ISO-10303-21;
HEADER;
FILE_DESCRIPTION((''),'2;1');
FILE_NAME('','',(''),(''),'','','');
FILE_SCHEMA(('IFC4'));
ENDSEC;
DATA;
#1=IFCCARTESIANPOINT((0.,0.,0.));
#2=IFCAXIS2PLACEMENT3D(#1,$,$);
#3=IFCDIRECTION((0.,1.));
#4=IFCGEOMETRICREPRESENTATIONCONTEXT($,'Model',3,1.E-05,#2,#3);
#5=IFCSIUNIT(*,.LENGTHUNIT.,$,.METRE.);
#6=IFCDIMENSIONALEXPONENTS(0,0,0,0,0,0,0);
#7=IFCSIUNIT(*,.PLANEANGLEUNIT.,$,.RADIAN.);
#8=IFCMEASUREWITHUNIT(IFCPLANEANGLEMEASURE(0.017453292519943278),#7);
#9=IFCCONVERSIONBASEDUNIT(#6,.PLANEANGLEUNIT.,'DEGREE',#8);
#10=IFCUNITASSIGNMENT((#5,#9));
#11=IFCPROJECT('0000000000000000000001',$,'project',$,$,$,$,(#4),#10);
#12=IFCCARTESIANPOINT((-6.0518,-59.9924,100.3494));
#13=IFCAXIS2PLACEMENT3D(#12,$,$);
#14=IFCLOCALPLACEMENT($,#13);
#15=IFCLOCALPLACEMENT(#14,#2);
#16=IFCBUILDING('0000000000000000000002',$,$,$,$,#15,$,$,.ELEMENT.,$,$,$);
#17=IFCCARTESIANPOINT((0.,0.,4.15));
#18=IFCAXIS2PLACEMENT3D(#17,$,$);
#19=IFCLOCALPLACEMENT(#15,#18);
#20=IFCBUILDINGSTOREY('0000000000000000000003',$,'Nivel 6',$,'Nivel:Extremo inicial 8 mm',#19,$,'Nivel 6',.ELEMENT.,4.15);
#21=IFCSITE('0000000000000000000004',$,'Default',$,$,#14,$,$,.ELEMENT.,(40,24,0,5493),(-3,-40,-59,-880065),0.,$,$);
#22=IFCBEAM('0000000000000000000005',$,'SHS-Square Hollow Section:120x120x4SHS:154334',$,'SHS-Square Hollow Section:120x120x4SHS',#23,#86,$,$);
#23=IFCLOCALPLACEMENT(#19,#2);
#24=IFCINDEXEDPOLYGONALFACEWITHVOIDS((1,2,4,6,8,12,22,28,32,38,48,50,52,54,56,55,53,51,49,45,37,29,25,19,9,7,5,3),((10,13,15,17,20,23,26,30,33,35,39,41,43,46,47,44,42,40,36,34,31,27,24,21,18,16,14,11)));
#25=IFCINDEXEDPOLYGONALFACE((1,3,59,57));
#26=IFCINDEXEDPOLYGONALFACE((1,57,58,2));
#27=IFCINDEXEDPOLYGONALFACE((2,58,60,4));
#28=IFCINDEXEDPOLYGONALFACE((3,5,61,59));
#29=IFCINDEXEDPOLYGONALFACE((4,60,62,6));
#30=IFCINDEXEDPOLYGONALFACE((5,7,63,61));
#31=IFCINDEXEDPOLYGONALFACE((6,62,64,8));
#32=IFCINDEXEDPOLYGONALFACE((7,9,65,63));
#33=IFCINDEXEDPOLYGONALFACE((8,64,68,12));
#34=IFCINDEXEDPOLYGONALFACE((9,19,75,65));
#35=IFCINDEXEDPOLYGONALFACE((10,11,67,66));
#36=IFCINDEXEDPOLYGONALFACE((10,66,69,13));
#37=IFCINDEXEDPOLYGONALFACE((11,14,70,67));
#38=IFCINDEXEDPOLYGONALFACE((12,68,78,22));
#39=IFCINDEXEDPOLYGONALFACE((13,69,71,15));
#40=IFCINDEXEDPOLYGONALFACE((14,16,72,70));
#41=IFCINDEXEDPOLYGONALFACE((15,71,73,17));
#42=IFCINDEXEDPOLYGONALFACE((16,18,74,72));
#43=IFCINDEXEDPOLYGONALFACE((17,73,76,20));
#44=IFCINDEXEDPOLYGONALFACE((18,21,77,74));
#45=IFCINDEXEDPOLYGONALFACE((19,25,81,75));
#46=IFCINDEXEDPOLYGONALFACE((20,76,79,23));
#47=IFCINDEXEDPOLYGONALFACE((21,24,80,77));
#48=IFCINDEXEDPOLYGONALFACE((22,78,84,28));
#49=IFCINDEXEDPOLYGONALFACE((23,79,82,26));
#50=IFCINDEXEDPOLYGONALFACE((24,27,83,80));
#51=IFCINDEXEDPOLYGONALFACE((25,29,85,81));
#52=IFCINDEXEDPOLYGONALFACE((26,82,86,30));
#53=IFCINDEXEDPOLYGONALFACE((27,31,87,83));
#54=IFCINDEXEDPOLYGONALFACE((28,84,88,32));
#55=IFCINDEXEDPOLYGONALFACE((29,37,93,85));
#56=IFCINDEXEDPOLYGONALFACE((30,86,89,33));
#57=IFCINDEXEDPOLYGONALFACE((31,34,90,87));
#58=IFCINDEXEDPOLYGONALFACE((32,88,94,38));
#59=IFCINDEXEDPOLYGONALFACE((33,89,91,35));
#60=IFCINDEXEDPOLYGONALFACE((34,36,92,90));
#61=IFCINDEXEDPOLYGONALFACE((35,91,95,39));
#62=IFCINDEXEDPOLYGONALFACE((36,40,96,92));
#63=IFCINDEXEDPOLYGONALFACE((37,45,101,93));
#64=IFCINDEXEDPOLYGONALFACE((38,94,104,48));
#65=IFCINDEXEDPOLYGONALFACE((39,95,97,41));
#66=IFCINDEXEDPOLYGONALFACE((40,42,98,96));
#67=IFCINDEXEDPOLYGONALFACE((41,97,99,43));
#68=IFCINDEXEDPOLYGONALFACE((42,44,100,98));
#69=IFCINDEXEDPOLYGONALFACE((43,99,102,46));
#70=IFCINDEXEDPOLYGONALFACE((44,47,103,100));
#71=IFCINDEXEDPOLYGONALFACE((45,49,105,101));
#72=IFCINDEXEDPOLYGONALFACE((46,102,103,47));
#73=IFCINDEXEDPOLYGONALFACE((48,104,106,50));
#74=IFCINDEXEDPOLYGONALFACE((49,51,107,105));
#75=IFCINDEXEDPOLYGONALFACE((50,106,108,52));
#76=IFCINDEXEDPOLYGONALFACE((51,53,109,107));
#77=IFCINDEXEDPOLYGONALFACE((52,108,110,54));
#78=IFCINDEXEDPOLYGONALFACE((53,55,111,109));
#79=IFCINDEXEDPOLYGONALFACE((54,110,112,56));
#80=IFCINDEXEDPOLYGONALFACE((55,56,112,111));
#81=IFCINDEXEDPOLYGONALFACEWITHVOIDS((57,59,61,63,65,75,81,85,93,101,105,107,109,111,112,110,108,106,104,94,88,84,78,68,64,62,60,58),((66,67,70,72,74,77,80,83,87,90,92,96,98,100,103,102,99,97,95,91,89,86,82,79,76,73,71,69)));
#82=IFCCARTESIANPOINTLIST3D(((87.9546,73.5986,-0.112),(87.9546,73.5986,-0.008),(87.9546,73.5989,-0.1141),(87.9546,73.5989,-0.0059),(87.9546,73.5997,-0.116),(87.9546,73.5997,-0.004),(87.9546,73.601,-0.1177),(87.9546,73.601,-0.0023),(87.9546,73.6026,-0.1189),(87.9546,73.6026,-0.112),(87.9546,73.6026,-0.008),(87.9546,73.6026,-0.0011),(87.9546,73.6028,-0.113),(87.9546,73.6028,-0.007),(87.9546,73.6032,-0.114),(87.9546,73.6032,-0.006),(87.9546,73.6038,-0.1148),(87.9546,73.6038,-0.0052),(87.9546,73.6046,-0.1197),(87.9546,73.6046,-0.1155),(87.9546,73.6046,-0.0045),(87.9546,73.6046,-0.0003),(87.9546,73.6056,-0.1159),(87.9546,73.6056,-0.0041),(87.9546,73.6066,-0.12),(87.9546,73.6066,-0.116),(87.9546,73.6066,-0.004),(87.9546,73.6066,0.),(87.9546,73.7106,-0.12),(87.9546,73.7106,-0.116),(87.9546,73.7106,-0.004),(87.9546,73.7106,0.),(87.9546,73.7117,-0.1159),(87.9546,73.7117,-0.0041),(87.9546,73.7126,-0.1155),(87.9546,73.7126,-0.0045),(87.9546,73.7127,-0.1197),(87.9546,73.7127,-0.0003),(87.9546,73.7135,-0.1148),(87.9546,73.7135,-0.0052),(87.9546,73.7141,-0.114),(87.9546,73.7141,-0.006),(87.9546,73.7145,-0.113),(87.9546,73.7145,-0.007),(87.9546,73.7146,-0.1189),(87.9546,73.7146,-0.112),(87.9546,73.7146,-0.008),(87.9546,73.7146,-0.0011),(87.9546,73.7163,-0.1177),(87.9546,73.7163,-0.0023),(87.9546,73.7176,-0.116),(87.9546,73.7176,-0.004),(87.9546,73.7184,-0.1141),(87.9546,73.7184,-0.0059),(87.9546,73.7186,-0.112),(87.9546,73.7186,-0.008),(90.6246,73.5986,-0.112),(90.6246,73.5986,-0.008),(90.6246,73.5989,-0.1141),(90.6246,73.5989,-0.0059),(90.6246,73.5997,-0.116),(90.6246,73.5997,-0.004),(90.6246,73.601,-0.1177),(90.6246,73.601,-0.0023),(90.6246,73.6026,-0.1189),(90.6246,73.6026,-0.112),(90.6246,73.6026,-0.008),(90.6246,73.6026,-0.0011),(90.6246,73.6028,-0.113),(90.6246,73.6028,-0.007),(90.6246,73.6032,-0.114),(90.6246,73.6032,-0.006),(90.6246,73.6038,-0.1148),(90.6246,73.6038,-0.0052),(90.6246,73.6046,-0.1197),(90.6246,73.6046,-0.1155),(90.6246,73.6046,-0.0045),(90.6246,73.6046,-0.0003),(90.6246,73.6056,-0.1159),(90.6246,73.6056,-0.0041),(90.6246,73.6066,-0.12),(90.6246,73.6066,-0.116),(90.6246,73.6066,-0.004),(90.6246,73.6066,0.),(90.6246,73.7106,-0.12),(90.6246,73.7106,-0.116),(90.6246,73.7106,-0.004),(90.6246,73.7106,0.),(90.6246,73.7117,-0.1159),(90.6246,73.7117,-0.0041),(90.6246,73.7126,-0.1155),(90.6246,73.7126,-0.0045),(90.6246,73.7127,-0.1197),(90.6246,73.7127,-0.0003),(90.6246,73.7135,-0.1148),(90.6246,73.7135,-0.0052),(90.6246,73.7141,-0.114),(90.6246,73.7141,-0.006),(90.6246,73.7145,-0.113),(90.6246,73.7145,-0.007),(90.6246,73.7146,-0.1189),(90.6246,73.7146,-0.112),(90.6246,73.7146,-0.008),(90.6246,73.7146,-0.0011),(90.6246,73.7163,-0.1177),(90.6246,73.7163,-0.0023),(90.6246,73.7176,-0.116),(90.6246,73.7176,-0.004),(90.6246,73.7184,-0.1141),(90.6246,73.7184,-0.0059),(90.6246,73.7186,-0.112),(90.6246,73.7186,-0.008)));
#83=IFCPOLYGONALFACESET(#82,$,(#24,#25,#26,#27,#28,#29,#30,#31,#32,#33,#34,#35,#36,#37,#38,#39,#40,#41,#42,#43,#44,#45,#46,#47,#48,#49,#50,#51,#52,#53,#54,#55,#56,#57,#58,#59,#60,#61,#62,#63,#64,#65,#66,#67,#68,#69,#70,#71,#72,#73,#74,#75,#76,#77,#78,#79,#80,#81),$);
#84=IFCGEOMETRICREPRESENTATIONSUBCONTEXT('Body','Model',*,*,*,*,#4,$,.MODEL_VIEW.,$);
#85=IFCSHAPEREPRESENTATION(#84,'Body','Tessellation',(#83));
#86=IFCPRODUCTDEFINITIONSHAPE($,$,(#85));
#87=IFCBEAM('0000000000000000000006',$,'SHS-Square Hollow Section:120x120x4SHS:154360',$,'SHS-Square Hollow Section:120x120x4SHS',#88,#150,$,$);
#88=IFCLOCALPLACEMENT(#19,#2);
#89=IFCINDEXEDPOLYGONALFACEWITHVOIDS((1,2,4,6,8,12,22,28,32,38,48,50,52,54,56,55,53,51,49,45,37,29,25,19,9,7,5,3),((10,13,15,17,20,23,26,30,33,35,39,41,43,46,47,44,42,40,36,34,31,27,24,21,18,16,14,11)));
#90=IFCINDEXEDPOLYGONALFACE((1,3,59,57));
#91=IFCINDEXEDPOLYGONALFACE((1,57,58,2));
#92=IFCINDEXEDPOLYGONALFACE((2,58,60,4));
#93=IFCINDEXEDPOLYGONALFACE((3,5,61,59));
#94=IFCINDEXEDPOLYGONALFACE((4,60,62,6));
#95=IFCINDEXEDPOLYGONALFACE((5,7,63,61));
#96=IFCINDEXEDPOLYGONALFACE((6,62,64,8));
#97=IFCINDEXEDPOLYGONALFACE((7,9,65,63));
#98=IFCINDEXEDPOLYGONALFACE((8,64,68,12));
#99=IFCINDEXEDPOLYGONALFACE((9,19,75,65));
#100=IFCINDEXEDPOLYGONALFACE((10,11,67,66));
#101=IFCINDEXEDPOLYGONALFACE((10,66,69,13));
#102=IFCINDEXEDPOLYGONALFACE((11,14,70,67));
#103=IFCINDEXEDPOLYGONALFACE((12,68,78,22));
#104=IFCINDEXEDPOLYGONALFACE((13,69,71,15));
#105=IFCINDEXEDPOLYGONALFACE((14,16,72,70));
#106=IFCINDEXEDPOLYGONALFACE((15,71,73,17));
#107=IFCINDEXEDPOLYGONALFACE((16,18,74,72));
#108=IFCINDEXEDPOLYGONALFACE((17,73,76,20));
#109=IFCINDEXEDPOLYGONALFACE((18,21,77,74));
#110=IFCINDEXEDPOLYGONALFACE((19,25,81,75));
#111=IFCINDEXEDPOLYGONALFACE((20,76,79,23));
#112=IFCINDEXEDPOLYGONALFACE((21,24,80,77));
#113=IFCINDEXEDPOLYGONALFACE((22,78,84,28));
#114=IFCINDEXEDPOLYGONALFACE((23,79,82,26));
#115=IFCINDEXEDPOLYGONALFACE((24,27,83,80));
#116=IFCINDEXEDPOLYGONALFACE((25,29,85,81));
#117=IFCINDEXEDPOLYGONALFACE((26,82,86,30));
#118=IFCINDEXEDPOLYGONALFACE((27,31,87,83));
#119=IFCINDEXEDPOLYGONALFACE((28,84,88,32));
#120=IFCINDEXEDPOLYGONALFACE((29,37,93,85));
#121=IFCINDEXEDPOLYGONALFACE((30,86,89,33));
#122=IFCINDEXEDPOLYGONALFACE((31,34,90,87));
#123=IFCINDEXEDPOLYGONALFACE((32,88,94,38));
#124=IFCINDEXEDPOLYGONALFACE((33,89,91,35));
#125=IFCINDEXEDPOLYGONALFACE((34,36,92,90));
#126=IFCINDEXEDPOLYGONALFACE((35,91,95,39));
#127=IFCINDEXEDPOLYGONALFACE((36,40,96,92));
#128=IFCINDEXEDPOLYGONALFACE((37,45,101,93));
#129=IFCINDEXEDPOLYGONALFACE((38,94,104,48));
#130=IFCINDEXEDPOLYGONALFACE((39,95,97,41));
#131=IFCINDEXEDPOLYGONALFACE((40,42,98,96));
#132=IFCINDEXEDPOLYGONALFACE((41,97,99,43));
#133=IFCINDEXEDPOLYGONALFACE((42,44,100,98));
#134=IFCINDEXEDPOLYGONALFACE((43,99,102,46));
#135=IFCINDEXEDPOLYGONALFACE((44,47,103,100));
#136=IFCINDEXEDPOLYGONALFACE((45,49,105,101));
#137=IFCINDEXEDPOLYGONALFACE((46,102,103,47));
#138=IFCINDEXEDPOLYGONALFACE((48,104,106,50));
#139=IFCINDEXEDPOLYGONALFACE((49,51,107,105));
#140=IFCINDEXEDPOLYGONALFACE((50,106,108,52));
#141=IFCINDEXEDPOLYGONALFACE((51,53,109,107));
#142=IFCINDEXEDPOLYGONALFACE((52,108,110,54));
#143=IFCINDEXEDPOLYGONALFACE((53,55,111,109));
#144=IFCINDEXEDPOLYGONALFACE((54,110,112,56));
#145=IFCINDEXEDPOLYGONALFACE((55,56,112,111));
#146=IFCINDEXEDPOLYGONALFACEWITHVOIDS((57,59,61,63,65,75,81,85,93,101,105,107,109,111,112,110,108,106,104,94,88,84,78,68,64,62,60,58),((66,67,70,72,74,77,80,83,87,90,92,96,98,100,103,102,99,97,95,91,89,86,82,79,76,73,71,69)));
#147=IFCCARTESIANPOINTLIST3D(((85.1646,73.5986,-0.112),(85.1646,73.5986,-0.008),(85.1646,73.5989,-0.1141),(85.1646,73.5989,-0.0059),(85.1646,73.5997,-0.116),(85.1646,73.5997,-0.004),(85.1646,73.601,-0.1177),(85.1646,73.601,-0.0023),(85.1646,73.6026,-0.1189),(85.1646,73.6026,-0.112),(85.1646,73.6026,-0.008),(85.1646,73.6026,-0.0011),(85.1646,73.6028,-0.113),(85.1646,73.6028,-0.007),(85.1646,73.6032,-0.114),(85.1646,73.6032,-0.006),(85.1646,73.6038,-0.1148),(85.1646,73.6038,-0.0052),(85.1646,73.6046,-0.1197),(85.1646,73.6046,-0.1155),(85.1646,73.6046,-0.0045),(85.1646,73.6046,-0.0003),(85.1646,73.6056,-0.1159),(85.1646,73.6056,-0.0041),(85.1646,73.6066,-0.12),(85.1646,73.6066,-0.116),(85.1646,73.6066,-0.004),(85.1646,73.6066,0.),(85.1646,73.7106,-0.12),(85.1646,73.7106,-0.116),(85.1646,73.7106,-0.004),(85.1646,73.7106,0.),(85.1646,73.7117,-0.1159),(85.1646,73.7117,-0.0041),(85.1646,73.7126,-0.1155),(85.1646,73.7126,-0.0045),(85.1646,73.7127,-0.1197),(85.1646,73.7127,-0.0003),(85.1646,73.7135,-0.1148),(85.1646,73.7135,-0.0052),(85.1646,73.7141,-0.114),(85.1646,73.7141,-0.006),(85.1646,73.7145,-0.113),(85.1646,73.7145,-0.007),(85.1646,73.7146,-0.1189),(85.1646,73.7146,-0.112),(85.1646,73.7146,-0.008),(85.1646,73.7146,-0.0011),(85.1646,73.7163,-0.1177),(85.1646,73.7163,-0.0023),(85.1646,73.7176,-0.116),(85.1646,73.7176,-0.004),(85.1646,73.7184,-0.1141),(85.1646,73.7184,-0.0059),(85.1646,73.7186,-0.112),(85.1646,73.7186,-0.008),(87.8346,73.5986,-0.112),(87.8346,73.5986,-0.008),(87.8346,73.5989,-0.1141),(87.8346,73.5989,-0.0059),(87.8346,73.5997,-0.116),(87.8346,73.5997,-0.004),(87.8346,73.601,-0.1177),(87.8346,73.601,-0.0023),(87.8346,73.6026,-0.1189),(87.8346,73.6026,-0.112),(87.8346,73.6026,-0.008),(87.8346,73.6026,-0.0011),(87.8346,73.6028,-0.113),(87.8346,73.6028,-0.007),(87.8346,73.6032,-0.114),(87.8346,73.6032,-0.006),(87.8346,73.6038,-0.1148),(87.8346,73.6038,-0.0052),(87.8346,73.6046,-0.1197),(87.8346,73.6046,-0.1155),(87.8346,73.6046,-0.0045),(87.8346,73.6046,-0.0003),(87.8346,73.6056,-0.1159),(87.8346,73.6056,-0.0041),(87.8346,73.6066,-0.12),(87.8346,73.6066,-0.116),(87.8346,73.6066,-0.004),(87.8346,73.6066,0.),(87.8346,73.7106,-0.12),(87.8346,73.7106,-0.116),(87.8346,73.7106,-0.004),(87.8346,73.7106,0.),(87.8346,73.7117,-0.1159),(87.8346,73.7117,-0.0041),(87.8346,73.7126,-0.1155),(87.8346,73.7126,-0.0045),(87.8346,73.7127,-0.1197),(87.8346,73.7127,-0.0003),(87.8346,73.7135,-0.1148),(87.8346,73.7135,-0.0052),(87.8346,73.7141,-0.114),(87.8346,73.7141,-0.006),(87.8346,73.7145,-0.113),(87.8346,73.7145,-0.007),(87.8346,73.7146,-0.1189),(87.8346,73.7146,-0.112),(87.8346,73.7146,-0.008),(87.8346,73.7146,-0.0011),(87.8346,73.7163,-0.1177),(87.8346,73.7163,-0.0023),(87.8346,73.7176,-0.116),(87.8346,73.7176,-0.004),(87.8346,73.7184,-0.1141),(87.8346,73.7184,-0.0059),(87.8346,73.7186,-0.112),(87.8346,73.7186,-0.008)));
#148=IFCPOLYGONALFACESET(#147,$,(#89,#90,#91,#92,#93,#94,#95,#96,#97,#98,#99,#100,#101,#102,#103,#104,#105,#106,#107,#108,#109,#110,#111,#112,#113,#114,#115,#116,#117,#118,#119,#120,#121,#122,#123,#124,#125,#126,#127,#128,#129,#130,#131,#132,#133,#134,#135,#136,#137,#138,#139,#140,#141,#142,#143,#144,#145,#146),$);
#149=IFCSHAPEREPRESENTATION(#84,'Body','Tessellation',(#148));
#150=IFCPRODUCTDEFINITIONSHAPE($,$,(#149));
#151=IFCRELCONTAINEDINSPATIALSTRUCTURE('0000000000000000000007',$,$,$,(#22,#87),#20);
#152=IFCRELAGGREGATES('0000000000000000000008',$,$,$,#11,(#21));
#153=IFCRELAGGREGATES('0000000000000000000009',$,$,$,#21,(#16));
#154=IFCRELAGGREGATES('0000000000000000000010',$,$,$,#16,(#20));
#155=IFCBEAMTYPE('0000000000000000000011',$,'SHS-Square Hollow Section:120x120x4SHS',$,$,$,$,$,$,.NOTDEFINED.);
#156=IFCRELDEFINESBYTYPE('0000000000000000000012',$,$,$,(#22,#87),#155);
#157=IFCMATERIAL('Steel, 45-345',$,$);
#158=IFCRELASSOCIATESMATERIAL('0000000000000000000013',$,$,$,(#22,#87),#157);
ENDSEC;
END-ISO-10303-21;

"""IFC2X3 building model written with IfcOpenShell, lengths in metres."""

from ifc_helpers import new_model, entity, si_unit, converted_unit, direction, frame, frame_2d, origin, place, context, subcontext, project, spatial, polyline, circle_curve, parameter, trimmed, segment, composite_curve, outline, extrude, material, type_object, element, save


model = new_model("IFC2X3")

# Units and contexts
model_context = context("Model", 3, precision=1e-05, world=origin(), true_north=direction((0.0, 1.0)))
body_context = subcontext(model_context, "Body", "Model", "MODEL_VIEW")
ifc_project = project(units=[si_unit("LENGTHUNIT", "METRE"), converted_unit("PLANEANGLEUNIT", "DEGREE", entity("IfcPlaneAngleMeasure", 0.017453292519943278), si_unit("PLANEANGLEUNIT", "RADIAN"), dimensions=[0, 0, 0, 0, 0, 0, 0])], contexts=[model_context])

# Site, building, storey
site_placement = place(None, frame((-6.0518, -59.9924, 100.3494)))
site = spatial("IfcSite", under=ifc_project, at=site_placement, Name="Default", CompositionType="ELEMENT", RefLatitude=(40, 24, 0, 5493), RefLongitude=(-3, -40, -59, -880065), RefElevation=0.0)
building_placement = place(site_placement, origin())
building = spatial("IfcBuilding", under=site, at=building_placement, CompositionType="ELEMENT")
storey_placement = place(building_placement, frame((0.0, 0.0, 4.15)))
storey = spatial("IfcBuildingStorey", under=building, at=storey_placement, Name="Nivel 6", ObjectType="Nivel:Extremo inicial 8 mm", LongName="Nivel 6", CompositionType="ELEMENT", Elevation=4.15)

# Beams
ifc_material_1 = material(Name="Steel, 45-345")
beam_type = type_object("IfcBeamType", Name="SHS-Square Hollow Section:120x120x4SHS", PredefinedType="NOTDEFINED")
beam_1_placement = place(storey_placement, frame((90.6846, 73.6586, 0.0), z_axis=(0.0, 0.0, 1.0), x_axis=(-1.0, 0.0, 0.0)))
element("IfcBeam", 1, at=beam_1_placement, inside=storey, type_object=beam_type, material=ifc_material_1, Name="SHS-Square Hollow Section:120x120x4SHS:154334", ObjectType="SHS-Square Hollow Section:120x120x4SHS", context=body_context, shape_type="SweptSolid", body=[
    extrude(outline(composite_curve([segment(trimmed(circle_curve(frame_2d((-0.052, -0.052), x_axis=(1.0, 0.0)), 0.008), [parameter(180.0)], [parameter(270.0)], True, "PARAMETER"), True, "CONTINUOUS"), segment(polyline([(-0.052, -0.06), (0.052, -0.06)]), True, "CONTINUOUS"), segment(trimmed(circle_curve(frame_2d((0.052, -0.052), x_axis=(1.0, 0.0)), 0.008), [parameter(270.0)], [parameter(0.0)], True, "PARAMETER"), True, "CONTINUOUS"), segment(polyline([(0.06, -0.052), (0.06, 0.052)]), True, "CONTINUOUS"), segment(trimmed(circle_curve(frame_2d((0.052, 0.052), x_axis=(1.0, 0.0)), 0.008), [parameter(360.0)], [parameter(90.0)], True, "PARAMETER"), True, "CONTINUOUS"), segment(polyline([(0.052, 0.06), (-0.052, 0.06)]), True, "CONTINUOUS"), segment(trimmed(circle_curve(frame_2d((-0.052, 0.052), x_axis=(1.0, 0.0)), 0.008), [parameter(90.0)], [parameter(180.0)], True, "PARAMETER"), True, "CONTINUOUS"), segment(polyline([(-0.06, 0.052), (-0.06, -0.052)]), True, "CONTINUOUS")], self_intersect=False), holes=[composite_curve([segment(polyline([(0.052, -0.056), (-0.052, -0.056)]), True, "CONTINUOUS"), segment(trimmed(circle_curve(frame_2d((-0.052, -0.052), x_axis=(1.0, 0.0)), 0.004), [parameter(180.0)], [parameter(270.0)], True, "PARAMETER"), False, "CONTINUOUS"), segment(polyline([(-0.056, -0.052), (-0.056, 0.052)]), True, "CONTINUOUS"), segment(trimmed(circle_curve(frame_2d((-0.052, 0.052), x_axis=(1.0, 0.0)), 0.004), [parameter(90.0)], [parameter(180.0)], True, "PARAMETER"), False, "CONTINUOUS"), segment(polyline([(-0.052, 0.056), (0.052, 0.056)]), True, "CONTINUOUS"), segment(trimmed(circle_curve(frame_2d((0.052, 0.052), x_axis=(1.0, 0.0)), 0.004), [parameter(0.0)], [parameter(90.0)], True, "PARAMETER"), False, "CONTINUOUS"), segment(polyline([(0.056, 0.052), (0.056, -0.052)]), True, "CONTINUOUS"), segment(trimmed(circle_curve(frame_2d((0.052, -0.052), x_axis=(1.0, 0.0)), 0.004), [parameter(270.0)], [parameter(0.0)], True, "PARAMETER"), False, "CONTINUOUS")], self_intersect=False)]), frame((0.06, 0.0, -0.06), z_axis=(1.0, 0.0, 0.0), x_axis=(0.0, -1.0, 0.0)), (0.0, 0.0, 1.0), 2.67),
])
beam_2_placement = place(storey_placement, frame((87.8946, 73.6586, 0.0), z_axis=(0.0, 0.0, 1.0), x_axis=(-1.0, 0.0, 0.0)))
element("IfcBeam", 2, at=beam_2_placement, inside=storey, type_object=beam_type, material=ifc_material_1, Name="SHS-Square Hollow Section:120x120x4SHS:154360", ObjectType="SHS-Square Hollow Section:120x120x4SHS", context=body_context, shape_type="SweptSolid", body=[
    extrude(outline(composite_curve([segment(trimmed(circle_curve(frame_2d((-0.052, -0.052), x_axis=(1.0, 0.0)), 0.008), [parameter(180.0)], [parameter(270.0)], True, "PARAMETER"), True, "CONTINUOUS"), segment(polyline([(-0.052, -0.06), (0.052, -0.06)]), True, "CONTINUOUS"), segment(trimmed(circle_curve(frame_2d((0.052, -0.052), x_axis=(1.0, 0.0)), 0.008), [parameter(270.0)], [parameter(0.0)], True, "PARAMETER"), True, "CONTINUOUS"), segment(polyline([(0.06, -0.052), (0.06, 0.052)]), True, "CONTINUOUS"), segment(trimmed(circle_curve(frame_2d((0.052, 0.052), x_axis=(1.0, 0.0)), 0.008), [parameter(360.0)], [parameter(90.0)], True, "PARAMETER"), True, "CONTINUOUS"), segment(polyline([(0.052, 0.06), (-0.052, 0.06)]), True, "CONTINUOUS"), segment(trimmed(circle_curve(frame_2d((-0.052, 0.052), x_axis=(1.0, 0.0)), 0.008), [parameter(90.0)], [parameter(180.0)], True, "PARAMETER"), True, "CONTINUOUS"), segment(polyline([(-0.06, 0.052), (-0.06, -0.052)]), True, "CONTINUOUS")], self_intersect=False), holes=[composite_curve([segment(polyline([(0.052, -0.056), (-0.052, -0.056)]), True, "CONTINUOUS"), segment(trimmed(circle_curve(frame_2d((-0.052, -0.052), x_axis=(1.0, 0.0)), 0.004), [parameter(180.0)], [parameter(270.0)], True, "PARAMETER"), False, "CONTINUOUS"), segment(polyline([(-0.056, -0.052), (-0.056, 0.052)]), True, "CONTINUOUS"), segment(trimmed(circle_curve(frame_2d((-0.052, 0.052), x_axis=(1.0, 0.0)), 0.004), [parameter(90.0)], [parameter(180.0)], True, "PARAMETER"), False, "CONTINUOUS"), segment(polyline([(-0.052, 0.056), (0.052, 0.056)]), True, "CONTINUOUS"), segment(trimmed(circle_curve(frame_2d((0.052, 0.052), x_axis=(1.0, 0.0)), 0.004), [parameter(0.0)], [parameter(90.0)], True, "PARAMETER"), False, "CONTINUOUS"), segment(polyline([(0.056, 0.052), (0.056, -0.052)]), True, "CONTINUOUS"), segment(trimmed(circle_curve(frame_2d((0.052, -0.052), x_axis=(1.0, 0.0)), 0.004), [parameter(270.0)], [parameter(0.0)], True, "PARAMETER"), False, "CONTINUOUS")], self_intersect=False)]), frame((0.06, 0.0, -0.06), z_axis=(1.0, 0.0, 0.0), x_axis=(0.0, -1.0, 0.0)), (0.0, 0.0, 1.0), 2.67),
])

save(model, "model.ifc")
